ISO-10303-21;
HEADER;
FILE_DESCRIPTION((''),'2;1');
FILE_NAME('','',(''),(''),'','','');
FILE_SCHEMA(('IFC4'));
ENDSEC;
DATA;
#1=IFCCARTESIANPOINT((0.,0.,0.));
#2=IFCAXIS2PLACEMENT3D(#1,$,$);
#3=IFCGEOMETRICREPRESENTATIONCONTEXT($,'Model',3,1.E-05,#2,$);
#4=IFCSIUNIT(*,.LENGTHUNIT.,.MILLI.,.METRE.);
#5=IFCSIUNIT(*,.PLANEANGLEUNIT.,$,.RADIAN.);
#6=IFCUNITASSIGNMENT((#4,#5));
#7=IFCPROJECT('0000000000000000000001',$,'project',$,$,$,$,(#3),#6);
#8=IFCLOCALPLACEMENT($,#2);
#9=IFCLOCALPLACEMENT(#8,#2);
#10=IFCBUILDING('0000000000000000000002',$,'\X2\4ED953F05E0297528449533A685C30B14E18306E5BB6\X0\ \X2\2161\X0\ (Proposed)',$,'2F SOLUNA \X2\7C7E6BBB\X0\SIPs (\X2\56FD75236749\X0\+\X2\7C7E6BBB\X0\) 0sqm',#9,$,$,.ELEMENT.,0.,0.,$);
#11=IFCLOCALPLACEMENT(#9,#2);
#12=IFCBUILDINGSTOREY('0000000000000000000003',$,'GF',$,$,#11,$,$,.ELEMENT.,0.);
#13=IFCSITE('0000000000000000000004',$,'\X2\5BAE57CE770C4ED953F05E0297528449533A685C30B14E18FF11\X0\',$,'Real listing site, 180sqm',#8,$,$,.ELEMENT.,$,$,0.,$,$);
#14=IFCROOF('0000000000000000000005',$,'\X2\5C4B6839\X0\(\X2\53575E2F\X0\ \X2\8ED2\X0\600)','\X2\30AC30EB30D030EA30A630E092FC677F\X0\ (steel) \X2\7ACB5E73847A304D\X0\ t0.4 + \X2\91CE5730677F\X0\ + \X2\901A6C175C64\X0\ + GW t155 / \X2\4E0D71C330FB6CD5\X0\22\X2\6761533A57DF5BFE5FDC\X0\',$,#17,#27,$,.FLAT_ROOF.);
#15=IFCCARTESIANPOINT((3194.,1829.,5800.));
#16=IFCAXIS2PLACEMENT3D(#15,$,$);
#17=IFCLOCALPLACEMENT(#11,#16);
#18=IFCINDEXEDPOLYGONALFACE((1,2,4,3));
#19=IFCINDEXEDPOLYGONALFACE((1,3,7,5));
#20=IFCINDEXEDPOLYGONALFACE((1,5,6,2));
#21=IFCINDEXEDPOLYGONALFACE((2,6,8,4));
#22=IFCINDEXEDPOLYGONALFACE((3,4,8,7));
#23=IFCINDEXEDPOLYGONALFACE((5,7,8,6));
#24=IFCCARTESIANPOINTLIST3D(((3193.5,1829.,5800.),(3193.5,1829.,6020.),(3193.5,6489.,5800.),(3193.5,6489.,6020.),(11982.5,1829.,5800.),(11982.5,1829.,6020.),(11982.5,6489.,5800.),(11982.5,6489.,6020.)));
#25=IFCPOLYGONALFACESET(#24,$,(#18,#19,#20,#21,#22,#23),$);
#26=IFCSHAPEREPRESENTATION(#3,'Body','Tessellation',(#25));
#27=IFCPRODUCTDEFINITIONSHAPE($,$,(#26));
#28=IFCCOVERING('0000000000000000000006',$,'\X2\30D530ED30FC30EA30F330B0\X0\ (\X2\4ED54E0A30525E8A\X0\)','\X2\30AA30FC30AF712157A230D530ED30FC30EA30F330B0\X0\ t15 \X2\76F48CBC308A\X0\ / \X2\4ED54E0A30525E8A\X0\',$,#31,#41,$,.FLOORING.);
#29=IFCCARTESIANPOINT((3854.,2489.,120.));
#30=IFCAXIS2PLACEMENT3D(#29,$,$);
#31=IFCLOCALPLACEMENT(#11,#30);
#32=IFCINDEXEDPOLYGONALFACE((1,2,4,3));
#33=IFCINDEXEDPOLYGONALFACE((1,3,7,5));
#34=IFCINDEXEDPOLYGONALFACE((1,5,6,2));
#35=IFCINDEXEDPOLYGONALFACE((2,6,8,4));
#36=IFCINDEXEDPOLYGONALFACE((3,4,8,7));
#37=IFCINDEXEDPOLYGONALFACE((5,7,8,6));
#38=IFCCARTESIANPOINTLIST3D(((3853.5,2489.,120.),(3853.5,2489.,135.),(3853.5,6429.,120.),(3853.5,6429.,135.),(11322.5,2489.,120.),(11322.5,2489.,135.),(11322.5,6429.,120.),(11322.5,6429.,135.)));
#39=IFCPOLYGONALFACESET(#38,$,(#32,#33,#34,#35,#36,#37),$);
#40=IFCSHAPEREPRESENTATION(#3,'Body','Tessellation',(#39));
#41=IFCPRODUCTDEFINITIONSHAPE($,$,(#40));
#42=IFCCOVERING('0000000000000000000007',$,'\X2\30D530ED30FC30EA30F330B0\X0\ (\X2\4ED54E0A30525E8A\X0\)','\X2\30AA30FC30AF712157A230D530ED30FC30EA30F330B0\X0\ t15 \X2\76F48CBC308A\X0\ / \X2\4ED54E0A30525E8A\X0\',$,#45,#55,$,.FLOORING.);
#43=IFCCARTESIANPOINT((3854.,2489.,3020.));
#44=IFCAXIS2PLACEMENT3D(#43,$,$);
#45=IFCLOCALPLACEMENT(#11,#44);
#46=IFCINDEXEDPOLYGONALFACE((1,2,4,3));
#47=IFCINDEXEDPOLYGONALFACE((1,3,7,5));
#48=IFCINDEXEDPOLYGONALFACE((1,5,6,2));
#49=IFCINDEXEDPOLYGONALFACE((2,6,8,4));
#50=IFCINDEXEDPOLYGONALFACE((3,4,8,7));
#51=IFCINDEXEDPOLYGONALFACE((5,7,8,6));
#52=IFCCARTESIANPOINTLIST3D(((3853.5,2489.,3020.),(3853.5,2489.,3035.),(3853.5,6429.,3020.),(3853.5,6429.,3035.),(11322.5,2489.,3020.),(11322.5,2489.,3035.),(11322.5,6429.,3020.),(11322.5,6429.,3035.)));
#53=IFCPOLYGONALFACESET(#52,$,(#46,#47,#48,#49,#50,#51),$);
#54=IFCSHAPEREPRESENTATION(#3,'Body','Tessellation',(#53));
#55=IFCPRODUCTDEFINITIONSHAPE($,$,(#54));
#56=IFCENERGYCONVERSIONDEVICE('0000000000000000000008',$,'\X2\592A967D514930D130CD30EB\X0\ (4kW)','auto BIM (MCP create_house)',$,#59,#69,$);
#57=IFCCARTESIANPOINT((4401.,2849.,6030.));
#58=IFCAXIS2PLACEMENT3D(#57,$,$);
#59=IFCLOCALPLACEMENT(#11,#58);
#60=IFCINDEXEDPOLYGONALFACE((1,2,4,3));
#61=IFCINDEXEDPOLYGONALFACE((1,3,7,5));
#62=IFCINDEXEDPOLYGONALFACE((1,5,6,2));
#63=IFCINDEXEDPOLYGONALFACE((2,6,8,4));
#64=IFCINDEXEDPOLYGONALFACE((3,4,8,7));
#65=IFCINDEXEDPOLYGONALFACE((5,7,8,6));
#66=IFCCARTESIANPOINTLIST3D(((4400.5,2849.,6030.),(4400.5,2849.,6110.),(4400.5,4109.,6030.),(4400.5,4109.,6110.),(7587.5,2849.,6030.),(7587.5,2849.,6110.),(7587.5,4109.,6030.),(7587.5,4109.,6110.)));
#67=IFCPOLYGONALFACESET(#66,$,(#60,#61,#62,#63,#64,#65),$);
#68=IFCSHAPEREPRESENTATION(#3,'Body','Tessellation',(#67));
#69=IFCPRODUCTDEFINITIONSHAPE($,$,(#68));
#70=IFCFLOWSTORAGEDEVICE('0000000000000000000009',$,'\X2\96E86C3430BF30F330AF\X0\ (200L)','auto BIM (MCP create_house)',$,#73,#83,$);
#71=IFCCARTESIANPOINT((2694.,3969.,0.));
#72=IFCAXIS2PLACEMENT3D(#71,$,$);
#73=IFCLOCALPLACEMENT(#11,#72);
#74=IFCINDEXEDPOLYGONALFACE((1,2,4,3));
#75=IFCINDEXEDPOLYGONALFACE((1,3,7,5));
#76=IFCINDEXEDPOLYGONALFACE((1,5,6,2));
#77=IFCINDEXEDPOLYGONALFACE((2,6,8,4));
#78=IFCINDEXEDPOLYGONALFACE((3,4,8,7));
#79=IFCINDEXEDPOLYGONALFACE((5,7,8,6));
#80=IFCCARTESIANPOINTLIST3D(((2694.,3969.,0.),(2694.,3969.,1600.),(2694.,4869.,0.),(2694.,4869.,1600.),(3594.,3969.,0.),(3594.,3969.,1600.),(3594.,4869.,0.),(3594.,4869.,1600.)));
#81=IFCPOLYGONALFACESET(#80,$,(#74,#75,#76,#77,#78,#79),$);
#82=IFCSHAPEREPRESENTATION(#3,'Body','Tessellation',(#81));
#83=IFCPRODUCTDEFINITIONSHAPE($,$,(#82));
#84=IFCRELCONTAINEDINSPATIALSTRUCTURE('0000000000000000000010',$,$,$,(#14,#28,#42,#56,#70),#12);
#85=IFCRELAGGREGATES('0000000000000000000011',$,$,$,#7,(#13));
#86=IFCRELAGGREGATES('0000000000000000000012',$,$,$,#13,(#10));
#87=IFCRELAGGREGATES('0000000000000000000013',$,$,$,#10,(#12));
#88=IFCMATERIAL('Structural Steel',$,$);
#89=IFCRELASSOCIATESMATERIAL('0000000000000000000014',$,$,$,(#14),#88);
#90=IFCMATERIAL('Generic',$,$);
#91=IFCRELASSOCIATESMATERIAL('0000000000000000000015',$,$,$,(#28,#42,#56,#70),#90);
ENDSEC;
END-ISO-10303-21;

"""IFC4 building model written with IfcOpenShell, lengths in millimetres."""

from ifc_helpers import new_model, si_unit, frame, frame_2d, origin, place, context, project, spatial, rectangle, extrude, material, element, save


model = new_model("IFC4")

# Units and contexts
model_context = context("Model", 3, precision=1e-05, world=origin())
ifc_project = project(units=[si_unit("LENGTHUNIT", "METRE", prefix="MILLI"), si_unit("PLANEANGLEUNIT", "RADIAN")], contexts=[model_context])

# Site, building, storey
site_placement = place(None, origin())
site = spatial("IfcSite", under=ifc_project, at=site_placement, Name="宮城県仙台市青葉区桜ケ丘１", ObjectType="Real listing site, 180sqm", CompositionType="ELEMENT", RefElevation=0.0)
building_placement = place(site_placement, origin())
building = spatial("IfcBuilding", under=site, at=building_placement, Name="仙台市青葉区桜ケ丘の家 Ⅱ (Proposed)", ObjectType="2F SOLUNA 籾殻SIPs (国産杉+籾殻) 0sqm", CompositionType="ELEMENT", ElevationOfRefHeight=0.0, ElevationOfTerrain=0.0)
storey_placement = place(building_placement, origin())
storey = spatial("IfcBuildingStorey", under=building, at=storey_placement, Name="GF", CompositionType="ELEMENT", Elevation=0.0)

# Roof
ifc_material_1 = material(Name="Structural Steel")
for number, where, name in (
    (1, (3194.0, 1829.0, 5800.0), "屋根(南帯 軒600)"),
):
    element("IfcRoof", number, at=place(storey_placement, frame(where)), inside=storey, material=ifc_material_1, Name=name, Description="ガルバリウム鋼板 (steel) 立平葺き t0.4 + 野地板 + 通気層 + GW t155 / 不燃・法22条区域対応", PredefinedType="FLAT_ROOF", context=model_context, shape_type="SweptSolid", body=[
        extrude(rectangle(XDim=8789.0, YDim=4660.0, at=frame_2d((4394.0, 2330.0))), frame((3194.0, 1829.0, 5800.0)), (0.0, 0.0, 1.0), 220.0),
    ])

# Coverings
ifc_material_2 = material(Name="Generic")
covering_1_placement = place(storey_placement, frame((3854.0, 2489.0, 120.0)))
element("IfcCovering", 2, at=covering_1_placement, inside=storey, material=ifc_material_2, Name="フローリング (仕上げ床)", Description="オーク無垢フローリング t15 直貼り / 仕上げ床", PredefinedType="FLOORING", context=model_context, shape_type="SweptSolid", body=[
    extrude(rectangle(XDim=7469.0, YDim=3940.0, at=frame_2d((3734.0, 1970.0))), frame((3854.0, 2489.0, 120.0)), (0.0, 0.0, 1.0), 15.0),
])
covering_2_placement = place(storey_placement, frame((3854.0, 2489.0, 3020.0)))
element("IfcCovering", 3, at=covering_2_placement, inside=storey, material=ifc_material_2, Name="フローリング (仕上げ床)", Description="オーク無垢フローリング t15 直貼り / 仕上げ床", PredefinedType="FLOORING", context=model_context, shape_type="SweptSolid", body=[
    extrude(rectangle(XDim=7469.0, YDim=3940.0, at=frame_2d((3734.0, 1970.0))), frame((3854.0, 2489.0, 3020.0)), (0.0, 0.0, 1.0), 15.0),
])

# Energy conversion device
energy_conversion_device_placement = place(storey_placement, frame((4401.0, 2849.0, 6030.0)))
element("IfcEnergyConversionDevice", 4, at=energy_conversion_device_placement, inside=storey, material=ifc_material_2, Name="太陽光パネル (4kW)", Description="auto BIM (MCP create_house)", context=model_context, shape_type="SweptSolid", body=[
    extrude(rectangle(XDim=3187.0, YDim=1260.0, at=frame_2d((1593.0, 630.0))), frame((4401.0, 2849.0, 6030.0)), (0.0, 0.0, 1.0), 80.0),
])

# Flow storage device
flow_storage_device_placement = place(storey_placement, frame((2694.0, 3969.0, 0.0)))
element("IfcFlowStorageDevice", 5, at=flow_storage_device_placement, inside=storey, material=ifc_material_2, Name="雨水タンク (200L)", Description="auto BIM (MCP create_house)", context=model_context, shape_type="SweptSolid", body=[
    extrude(rectangle(XDim=900.0, YDim=900.0, at=frame_2d((450.0, 450.0))), frame((2694.0, 3969.0, 0.0)), (0.0, 0.0, 1.0), 1600.0),
])

save(model, "model.ifc")
